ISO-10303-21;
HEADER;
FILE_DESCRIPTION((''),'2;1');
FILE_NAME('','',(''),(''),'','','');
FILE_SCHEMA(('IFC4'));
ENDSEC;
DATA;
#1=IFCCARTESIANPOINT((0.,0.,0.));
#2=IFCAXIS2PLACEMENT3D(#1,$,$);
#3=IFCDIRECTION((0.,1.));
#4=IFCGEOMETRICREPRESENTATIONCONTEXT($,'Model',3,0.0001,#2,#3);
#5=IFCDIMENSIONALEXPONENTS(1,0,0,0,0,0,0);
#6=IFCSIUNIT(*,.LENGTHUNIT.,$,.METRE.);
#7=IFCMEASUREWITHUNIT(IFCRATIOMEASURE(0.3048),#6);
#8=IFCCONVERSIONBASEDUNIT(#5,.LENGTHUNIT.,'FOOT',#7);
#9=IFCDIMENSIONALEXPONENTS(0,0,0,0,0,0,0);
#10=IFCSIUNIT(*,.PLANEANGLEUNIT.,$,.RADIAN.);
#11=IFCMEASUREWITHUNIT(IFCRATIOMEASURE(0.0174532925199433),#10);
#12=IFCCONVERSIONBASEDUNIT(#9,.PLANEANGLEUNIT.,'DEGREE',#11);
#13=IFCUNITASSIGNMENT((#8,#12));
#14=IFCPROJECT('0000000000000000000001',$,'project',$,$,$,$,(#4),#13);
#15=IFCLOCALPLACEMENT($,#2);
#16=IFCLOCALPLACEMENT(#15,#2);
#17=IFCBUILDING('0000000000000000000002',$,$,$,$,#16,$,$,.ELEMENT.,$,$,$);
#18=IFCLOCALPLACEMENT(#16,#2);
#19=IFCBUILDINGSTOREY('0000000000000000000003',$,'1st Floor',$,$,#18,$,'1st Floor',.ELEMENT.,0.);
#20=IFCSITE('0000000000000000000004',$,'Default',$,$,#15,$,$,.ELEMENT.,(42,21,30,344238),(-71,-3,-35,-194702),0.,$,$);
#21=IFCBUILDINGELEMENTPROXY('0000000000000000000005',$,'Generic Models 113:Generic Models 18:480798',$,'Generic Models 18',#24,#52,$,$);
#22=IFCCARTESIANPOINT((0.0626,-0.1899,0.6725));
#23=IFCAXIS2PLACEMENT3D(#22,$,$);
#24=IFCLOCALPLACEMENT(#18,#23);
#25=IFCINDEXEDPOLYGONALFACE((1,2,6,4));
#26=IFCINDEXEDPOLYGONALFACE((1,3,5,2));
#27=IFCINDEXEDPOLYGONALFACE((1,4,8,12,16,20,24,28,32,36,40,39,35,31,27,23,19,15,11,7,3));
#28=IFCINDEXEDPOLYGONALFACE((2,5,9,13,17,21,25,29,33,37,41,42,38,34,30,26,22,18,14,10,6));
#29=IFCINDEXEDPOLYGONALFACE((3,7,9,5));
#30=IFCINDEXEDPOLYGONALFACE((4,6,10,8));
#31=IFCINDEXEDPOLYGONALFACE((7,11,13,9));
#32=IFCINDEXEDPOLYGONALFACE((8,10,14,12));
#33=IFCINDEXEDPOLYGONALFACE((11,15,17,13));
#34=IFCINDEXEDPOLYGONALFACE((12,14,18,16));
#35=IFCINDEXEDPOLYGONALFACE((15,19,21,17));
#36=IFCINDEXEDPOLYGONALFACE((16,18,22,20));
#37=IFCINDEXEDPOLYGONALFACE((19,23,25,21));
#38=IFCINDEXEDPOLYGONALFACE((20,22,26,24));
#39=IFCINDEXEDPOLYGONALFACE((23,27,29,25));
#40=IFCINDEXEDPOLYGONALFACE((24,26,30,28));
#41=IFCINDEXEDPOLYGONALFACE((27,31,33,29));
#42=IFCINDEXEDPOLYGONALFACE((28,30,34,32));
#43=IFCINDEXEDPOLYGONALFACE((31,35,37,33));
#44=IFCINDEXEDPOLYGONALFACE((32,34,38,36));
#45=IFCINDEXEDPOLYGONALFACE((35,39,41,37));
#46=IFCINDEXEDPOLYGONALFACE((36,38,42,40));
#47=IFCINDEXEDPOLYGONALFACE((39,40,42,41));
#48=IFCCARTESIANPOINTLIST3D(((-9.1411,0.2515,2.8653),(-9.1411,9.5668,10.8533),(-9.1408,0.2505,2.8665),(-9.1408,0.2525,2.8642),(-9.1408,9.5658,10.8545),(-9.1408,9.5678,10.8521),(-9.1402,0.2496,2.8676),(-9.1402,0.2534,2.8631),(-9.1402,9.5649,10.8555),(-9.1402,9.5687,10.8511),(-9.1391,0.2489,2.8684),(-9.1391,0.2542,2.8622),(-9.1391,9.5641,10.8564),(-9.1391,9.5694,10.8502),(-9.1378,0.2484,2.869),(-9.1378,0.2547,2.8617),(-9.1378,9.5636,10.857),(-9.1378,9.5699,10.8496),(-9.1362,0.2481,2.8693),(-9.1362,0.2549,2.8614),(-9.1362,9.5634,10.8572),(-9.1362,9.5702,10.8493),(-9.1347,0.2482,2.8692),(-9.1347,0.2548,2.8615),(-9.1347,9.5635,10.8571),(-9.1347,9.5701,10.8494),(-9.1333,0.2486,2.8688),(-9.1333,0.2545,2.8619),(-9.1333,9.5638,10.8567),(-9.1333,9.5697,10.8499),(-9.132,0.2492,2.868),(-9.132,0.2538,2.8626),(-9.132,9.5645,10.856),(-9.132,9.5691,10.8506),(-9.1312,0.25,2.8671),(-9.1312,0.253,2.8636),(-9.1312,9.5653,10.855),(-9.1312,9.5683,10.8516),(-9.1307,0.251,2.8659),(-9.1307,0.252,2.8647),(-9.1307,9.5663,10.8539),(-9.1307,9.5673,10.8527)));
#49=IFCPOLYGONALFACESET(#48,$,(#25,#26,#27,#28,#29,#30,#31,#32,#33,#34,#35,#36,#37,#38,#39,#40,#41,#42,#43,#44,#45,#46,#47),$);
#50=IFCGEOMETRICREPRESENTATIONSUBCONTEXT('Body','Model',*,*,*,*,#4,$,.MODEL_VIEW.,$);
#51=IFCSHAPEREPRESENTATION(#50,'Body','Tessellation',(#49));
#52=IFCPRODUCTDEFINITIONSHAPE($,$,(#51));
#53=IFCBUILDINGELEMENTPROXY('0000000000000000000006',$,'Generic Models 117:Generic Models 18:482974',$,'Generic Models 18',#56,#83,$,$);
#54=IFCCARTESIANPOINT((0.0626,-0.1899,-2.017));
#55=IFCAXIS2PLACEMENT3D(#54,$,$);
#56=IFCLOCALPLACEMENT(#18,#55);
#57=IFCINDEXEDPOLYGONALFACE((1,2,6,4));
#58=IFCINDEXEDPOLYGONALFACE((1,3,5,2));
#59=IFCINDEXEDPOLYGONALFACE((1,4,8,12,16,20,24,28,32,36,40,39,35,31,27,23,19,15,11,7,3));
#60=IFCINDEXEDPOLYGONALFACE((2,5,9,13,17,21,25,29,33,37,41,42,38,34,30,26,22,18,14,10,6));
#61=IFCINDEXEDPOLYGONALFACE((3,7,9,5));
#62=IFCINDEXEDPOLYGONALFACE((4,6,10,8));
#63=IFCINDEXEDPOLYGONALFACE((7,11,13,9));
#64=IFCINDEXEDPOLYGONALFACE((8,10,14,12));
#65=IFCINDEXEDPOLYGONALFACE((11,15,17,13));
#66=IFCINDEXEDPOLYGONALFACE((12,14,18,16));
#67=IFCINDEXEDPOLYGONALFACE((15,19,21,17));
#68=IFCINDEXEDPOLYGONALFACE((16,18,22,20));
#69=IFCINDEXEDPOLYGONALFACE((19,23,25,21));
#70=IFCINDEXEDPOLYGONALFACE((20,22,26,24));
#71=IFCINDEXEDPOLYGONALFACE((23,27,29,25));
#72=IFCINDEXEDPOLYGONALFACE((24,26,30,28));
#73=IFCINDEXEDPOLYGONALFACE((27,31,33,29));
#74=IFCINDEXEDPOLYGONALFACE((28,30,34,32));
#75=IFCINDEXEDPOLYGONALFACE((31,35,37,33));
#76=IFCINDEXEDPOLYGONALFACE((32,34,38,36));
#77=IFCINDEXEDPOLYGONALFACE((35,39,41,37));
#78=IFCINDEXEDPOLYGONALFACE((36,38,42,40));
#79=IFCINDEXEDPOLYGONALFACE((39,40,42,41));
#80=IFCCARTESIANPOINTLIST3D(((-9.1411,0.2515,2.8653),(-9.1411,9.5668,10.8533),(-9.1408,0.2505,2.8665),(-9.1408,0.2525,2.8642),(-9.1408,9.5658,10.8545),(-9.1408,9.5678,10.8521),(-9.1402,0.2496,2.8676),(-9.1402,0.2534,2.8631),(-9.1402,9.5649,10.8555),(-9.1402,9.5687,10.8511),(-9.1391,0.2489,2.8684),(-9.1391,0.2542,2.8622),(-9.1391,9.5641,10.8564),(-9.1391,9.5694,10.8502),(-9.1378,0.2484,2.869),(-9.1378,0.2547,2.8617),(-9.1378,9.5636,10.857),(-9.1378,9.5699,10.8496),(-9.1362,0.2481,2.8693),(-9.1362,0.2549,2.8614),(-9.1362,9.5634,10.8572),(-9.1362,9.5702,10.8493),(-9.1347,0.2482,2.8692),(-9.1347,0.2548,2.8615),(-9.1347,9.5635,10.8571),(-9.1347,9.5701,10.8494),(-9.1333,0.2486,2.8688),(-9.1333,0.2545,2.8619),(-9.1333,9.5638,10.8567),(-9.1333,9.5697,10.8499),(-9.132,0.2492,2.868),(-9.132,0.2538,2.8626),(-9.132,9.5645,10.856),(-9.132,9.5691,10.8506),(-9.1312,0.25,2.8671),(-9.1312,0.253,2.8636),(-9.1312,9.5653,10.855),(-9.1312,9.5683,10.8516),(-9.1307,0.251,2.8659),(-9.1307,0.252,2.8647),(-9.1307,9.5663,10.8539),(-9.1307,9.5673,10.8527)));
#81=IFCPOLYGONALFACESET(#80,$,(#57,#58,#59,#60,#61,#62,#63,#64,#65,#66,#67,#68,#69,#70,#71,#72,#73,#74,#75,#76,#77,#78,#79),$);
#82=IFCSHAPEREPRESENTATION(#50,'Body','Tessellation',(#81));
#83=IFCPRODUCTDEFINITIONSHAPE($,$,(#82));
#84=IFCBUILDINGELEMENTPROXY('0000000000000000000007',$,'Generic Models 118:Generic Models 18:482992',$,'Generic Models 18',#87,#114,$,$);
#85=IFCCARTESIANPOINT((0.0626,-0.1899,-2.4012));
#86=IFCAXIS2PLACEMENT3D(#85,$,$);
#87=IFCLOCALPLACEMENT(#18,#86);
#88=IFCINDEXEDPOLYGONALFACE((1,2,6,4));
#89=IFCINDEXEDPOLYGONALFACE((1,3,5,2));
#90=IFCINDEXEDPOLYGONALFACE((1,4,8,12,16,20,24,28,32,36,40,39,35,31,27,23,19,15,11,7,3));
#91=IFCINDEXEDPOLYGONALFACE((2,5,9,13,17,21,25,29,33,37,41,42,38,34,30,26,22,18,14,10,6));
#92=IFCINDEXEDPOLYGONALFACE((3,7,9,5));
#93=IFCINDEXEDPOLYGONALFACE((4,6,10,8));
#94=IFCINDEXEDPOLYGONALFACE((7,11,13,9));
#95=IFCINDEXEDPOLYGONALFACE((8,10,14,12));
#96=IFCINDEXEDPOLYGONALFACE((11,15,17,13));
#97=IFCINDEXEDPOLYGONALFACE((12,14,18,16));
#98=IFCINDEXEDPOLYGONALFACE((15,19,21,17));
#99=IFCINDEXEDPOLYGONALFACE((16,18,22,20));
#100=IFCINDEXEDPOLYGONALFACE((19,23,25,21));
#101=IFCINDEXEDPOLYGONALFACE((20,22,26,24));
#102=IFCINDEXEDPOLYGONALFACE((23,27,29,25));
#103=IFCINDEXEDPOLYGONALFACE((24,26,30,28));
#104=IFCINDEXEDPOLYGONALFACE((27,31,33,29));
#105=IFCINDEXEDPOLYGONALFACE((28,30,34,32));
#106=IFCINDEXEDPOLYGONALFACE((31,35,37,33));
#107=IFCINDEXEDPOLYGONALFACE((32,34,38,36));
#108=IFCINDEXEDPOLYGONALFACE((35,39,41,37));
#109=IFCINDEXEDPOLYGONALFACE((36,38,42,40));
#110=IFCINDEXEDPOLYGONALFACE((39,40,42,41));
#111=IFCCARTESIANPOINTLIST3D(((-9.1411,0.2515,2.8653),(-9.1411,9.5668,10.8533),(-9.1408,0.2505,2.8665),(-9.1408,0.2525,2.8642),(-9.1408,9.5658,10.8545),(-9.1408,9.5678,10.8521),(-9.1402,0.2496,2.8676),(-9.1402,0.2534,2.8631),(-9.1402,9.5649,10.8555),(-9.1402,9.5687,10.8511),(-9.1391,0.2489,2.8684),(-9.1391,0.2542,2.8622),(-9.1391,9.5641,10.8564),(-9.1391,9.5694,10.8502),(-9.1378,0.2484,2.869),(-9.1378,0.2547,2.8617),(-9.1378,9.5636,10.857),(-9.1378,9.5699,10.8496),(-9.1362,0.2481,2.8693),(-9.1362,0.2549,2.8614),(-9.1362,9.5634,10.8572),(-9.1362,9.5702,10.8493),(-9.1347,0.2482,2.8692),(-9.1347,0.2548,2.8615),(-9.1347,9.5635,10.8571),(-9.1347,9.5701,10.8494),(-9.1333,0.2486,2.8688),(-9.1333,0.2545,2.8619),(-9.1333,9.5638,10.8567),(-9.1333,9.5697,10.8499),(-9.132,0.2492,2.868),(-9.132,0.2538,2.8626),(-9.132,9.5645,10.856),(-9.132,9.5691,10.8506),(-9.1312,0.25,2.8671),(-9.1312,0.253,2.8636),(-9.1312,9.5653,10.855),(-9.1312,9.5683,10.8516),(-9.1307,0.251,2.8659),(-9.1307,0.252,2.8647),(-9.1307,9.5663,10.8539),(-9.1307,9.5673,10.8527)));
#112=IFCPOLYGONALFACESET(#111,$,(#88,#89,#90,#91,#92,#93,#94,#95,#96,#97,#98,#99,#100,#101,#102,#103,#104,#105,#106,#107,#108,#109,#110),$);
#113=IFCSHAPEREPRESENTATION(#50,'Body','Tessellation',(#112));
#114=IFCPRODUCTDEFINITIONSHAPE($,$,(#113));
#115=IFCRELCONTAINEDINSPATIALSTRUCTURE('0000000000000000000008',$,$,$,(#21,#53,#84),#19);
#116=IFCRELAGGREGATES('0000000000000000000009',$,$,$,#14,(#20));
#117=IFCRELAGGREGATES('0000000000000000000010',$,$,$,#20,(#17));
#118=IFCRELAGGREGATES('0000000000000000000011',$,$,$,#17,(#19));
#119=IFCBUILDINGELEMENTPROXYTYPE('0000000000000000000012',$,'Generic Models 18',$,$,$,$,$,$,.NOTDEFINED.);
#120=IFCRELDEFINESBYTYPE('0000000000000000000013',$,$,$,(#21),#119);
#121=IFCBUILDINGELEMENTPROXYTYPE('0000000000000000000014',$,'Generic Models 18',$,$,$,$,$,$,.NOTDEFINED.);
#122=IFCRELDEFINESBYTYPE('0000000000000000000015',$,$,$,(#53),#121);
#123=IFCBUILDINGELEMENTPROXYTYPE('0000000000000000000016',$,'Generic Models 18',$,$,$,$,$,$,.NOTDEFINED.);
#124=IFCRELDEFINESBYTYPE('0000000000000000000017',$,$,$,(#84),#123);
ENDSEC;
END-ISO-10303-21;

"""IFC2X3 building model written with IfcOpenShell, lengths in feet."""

from ifc_helpers import new_model, entity, si_unit, converted_unit, direction, frame, origin, origin_2d_with_axis, place, context, subcontext, project, spatial, circle, extrude, source, transform, mapped, type_object, type_shapes, element, save


model = new_model("IFC2X3")

# Units and contexts
model_context = context("Model", 3, precision=0.0001, world=origin(), true_north=direction((0.0, 1.0)))
body_context = subcontext(model_context, "Body", "Model", "MODEL_VIEW")
ifc_project = project(units=[converted_unit("LENGTHUNIT", "FOOT", entity("IfcRatioMeasure", 0.3048), si_unit("LENGTHUNIT", "METRE"), dimensions=[1, 0, 0, 0, 0, 0, 0]), converted_unit("PLANEANGLEUNIT", "DEGREE", entity("IfcRatioMeasure", 0.0174532925199433), si_unit("PLANEANGLEUNIT", "RADIAN"), dimensions=[0, 0, 0, 0, 0, 0, 0])], contexts=[model_context])

# Site, building, storey
site_placement = place(None, origin())
site = spatial("IfcSite", under=ifc_project, at=site_placement, Name="Default", CompositionType="ELEMENT", RefLatitude=(42, 21, 30, 344238), RefLongitude=(-71, -3, -35, -194702), RefElevation=0.0)
building_placement = place(site_placement, origin())
building = spatial("IfcBuilding", under=site, at=building_placement, CompositionType="ELEMENT")
storey_placement = place(building_placement, origin())
storey = spatial("IfcBuildingStorey", under=building, at=storey_placement, Name="1st Floor", LongName="1st Floor", CompositionType="ELEMENT", Elevation=0.0)

# Building element proxies
building_element_proxy_type_1 = type_object("IfcBuildingElementProxyType", Name="Generic Models 18", PredefinedType="NOTDEFINED")
shared_shape_1 = source(origin(), body_context, "Body", "SweptSolid", [
    extrude(circle(Radius=0.0052, at=origin_2d_with_axis()), frame((-9.1359, 0.2515, 2.8653), z_axis=(0.0, 0.759118, 0.650953), x_axis=(-1.0, 0.0, 0.0)), (0.0, 0.0, 1.0), 12.2712),
])
type_shapes(building_element_proxy_type_1, [shared_shape_1])
proxy_1_placement = place(storey_placement, frame((0.0626, -0.1899, 0.6725)))
element("IfcBuildingElementProxy", 1, at=proxy_1_placement, inside=storey, type_object=building_element_proxy_type_1, Name="Generic Models 113:Generic Models 18:480798", ObjectType="Generic Models 18", context=body_context, shape_type="MappedRepresentation", body=[
    mapped(shared_shape_1, transform((0.0, 0.0, 0.0), scale=1.0)),
])
building_element_proxy_type_2 = type_object("IfcBuildingElementProxyType", Name="Generic Models 18", PredefinedType="NOTDEFINED")
shared_shape_2 = source(origin(), body_context, "Body", "SweptSolid", [
    extrude(circle(Radius=0.0052, at=origin_2d_with_axis()), frame((-9.1359, 0.2515, 2.8653), z_axis=(0.0, 0.759118, 0.650953), x_axis=(-1.0, 0.0, 0.0)), (0.0, 0.0, 1.0), 12.2712),
])
type_shapes(building_element_proxy_type_2, [shared_shape_2])
proxy_2_placement = place(storey_placement, frame((0.0626, -0.1899, -2.017)))
element("IfcBuildingElementProxy", 2, at=proxy_2_placement, inside=storey, type_object=building_element_proxy_type_2, Name="Generic Models 117:Generic Models 18:482974", ObjectType="Generic Models 18", context=body_context, shape_type="MappedRepresentation", body=[
    mapped(shared_shape_2, transform((0.0, 0.0, 0.0), scale=1.0)),
])
building_element_proxy_type_3 = type_object("IfcBuildingElementProxyType", Name="Generic Models 18", PredefinedType="NOTDEFINED")
shared_shape_3 = source(origin(), body_context, "Body", "SweptSolid", [
    extrude(circle(Radius=0.0052, at=origin_2d_with_axis()), frame((-9.1359, 0.2515, 2.8653), z_axis=(0.0, 0.759118, 0.650953), x_axis=(-1.0, 0.0, 0.0)), (0.0, 0.0, 1.0), 12.2712),
])
type_shapes(building_element_proxy_type_3, [shared_shape_3])
proxy_3_placement = place(storey_placement, frame((0.0626, -0.1899, -2.4012)))
element("IfcBuildingElementProxy", 3, at=proxy_3_placement, inside=storey, type_object=building_element_proxy_type_3, Name="Generic Models 118:Generic Models 18:482992", ObjectType="Generic Models 18", context=body_context, shape_type="MappedRepresentation", body=[
    mapped(shared_shape_3, transform((0.0, 0.0, 0.0), scale=1.0)),
])

save(model, "model.ifc")
